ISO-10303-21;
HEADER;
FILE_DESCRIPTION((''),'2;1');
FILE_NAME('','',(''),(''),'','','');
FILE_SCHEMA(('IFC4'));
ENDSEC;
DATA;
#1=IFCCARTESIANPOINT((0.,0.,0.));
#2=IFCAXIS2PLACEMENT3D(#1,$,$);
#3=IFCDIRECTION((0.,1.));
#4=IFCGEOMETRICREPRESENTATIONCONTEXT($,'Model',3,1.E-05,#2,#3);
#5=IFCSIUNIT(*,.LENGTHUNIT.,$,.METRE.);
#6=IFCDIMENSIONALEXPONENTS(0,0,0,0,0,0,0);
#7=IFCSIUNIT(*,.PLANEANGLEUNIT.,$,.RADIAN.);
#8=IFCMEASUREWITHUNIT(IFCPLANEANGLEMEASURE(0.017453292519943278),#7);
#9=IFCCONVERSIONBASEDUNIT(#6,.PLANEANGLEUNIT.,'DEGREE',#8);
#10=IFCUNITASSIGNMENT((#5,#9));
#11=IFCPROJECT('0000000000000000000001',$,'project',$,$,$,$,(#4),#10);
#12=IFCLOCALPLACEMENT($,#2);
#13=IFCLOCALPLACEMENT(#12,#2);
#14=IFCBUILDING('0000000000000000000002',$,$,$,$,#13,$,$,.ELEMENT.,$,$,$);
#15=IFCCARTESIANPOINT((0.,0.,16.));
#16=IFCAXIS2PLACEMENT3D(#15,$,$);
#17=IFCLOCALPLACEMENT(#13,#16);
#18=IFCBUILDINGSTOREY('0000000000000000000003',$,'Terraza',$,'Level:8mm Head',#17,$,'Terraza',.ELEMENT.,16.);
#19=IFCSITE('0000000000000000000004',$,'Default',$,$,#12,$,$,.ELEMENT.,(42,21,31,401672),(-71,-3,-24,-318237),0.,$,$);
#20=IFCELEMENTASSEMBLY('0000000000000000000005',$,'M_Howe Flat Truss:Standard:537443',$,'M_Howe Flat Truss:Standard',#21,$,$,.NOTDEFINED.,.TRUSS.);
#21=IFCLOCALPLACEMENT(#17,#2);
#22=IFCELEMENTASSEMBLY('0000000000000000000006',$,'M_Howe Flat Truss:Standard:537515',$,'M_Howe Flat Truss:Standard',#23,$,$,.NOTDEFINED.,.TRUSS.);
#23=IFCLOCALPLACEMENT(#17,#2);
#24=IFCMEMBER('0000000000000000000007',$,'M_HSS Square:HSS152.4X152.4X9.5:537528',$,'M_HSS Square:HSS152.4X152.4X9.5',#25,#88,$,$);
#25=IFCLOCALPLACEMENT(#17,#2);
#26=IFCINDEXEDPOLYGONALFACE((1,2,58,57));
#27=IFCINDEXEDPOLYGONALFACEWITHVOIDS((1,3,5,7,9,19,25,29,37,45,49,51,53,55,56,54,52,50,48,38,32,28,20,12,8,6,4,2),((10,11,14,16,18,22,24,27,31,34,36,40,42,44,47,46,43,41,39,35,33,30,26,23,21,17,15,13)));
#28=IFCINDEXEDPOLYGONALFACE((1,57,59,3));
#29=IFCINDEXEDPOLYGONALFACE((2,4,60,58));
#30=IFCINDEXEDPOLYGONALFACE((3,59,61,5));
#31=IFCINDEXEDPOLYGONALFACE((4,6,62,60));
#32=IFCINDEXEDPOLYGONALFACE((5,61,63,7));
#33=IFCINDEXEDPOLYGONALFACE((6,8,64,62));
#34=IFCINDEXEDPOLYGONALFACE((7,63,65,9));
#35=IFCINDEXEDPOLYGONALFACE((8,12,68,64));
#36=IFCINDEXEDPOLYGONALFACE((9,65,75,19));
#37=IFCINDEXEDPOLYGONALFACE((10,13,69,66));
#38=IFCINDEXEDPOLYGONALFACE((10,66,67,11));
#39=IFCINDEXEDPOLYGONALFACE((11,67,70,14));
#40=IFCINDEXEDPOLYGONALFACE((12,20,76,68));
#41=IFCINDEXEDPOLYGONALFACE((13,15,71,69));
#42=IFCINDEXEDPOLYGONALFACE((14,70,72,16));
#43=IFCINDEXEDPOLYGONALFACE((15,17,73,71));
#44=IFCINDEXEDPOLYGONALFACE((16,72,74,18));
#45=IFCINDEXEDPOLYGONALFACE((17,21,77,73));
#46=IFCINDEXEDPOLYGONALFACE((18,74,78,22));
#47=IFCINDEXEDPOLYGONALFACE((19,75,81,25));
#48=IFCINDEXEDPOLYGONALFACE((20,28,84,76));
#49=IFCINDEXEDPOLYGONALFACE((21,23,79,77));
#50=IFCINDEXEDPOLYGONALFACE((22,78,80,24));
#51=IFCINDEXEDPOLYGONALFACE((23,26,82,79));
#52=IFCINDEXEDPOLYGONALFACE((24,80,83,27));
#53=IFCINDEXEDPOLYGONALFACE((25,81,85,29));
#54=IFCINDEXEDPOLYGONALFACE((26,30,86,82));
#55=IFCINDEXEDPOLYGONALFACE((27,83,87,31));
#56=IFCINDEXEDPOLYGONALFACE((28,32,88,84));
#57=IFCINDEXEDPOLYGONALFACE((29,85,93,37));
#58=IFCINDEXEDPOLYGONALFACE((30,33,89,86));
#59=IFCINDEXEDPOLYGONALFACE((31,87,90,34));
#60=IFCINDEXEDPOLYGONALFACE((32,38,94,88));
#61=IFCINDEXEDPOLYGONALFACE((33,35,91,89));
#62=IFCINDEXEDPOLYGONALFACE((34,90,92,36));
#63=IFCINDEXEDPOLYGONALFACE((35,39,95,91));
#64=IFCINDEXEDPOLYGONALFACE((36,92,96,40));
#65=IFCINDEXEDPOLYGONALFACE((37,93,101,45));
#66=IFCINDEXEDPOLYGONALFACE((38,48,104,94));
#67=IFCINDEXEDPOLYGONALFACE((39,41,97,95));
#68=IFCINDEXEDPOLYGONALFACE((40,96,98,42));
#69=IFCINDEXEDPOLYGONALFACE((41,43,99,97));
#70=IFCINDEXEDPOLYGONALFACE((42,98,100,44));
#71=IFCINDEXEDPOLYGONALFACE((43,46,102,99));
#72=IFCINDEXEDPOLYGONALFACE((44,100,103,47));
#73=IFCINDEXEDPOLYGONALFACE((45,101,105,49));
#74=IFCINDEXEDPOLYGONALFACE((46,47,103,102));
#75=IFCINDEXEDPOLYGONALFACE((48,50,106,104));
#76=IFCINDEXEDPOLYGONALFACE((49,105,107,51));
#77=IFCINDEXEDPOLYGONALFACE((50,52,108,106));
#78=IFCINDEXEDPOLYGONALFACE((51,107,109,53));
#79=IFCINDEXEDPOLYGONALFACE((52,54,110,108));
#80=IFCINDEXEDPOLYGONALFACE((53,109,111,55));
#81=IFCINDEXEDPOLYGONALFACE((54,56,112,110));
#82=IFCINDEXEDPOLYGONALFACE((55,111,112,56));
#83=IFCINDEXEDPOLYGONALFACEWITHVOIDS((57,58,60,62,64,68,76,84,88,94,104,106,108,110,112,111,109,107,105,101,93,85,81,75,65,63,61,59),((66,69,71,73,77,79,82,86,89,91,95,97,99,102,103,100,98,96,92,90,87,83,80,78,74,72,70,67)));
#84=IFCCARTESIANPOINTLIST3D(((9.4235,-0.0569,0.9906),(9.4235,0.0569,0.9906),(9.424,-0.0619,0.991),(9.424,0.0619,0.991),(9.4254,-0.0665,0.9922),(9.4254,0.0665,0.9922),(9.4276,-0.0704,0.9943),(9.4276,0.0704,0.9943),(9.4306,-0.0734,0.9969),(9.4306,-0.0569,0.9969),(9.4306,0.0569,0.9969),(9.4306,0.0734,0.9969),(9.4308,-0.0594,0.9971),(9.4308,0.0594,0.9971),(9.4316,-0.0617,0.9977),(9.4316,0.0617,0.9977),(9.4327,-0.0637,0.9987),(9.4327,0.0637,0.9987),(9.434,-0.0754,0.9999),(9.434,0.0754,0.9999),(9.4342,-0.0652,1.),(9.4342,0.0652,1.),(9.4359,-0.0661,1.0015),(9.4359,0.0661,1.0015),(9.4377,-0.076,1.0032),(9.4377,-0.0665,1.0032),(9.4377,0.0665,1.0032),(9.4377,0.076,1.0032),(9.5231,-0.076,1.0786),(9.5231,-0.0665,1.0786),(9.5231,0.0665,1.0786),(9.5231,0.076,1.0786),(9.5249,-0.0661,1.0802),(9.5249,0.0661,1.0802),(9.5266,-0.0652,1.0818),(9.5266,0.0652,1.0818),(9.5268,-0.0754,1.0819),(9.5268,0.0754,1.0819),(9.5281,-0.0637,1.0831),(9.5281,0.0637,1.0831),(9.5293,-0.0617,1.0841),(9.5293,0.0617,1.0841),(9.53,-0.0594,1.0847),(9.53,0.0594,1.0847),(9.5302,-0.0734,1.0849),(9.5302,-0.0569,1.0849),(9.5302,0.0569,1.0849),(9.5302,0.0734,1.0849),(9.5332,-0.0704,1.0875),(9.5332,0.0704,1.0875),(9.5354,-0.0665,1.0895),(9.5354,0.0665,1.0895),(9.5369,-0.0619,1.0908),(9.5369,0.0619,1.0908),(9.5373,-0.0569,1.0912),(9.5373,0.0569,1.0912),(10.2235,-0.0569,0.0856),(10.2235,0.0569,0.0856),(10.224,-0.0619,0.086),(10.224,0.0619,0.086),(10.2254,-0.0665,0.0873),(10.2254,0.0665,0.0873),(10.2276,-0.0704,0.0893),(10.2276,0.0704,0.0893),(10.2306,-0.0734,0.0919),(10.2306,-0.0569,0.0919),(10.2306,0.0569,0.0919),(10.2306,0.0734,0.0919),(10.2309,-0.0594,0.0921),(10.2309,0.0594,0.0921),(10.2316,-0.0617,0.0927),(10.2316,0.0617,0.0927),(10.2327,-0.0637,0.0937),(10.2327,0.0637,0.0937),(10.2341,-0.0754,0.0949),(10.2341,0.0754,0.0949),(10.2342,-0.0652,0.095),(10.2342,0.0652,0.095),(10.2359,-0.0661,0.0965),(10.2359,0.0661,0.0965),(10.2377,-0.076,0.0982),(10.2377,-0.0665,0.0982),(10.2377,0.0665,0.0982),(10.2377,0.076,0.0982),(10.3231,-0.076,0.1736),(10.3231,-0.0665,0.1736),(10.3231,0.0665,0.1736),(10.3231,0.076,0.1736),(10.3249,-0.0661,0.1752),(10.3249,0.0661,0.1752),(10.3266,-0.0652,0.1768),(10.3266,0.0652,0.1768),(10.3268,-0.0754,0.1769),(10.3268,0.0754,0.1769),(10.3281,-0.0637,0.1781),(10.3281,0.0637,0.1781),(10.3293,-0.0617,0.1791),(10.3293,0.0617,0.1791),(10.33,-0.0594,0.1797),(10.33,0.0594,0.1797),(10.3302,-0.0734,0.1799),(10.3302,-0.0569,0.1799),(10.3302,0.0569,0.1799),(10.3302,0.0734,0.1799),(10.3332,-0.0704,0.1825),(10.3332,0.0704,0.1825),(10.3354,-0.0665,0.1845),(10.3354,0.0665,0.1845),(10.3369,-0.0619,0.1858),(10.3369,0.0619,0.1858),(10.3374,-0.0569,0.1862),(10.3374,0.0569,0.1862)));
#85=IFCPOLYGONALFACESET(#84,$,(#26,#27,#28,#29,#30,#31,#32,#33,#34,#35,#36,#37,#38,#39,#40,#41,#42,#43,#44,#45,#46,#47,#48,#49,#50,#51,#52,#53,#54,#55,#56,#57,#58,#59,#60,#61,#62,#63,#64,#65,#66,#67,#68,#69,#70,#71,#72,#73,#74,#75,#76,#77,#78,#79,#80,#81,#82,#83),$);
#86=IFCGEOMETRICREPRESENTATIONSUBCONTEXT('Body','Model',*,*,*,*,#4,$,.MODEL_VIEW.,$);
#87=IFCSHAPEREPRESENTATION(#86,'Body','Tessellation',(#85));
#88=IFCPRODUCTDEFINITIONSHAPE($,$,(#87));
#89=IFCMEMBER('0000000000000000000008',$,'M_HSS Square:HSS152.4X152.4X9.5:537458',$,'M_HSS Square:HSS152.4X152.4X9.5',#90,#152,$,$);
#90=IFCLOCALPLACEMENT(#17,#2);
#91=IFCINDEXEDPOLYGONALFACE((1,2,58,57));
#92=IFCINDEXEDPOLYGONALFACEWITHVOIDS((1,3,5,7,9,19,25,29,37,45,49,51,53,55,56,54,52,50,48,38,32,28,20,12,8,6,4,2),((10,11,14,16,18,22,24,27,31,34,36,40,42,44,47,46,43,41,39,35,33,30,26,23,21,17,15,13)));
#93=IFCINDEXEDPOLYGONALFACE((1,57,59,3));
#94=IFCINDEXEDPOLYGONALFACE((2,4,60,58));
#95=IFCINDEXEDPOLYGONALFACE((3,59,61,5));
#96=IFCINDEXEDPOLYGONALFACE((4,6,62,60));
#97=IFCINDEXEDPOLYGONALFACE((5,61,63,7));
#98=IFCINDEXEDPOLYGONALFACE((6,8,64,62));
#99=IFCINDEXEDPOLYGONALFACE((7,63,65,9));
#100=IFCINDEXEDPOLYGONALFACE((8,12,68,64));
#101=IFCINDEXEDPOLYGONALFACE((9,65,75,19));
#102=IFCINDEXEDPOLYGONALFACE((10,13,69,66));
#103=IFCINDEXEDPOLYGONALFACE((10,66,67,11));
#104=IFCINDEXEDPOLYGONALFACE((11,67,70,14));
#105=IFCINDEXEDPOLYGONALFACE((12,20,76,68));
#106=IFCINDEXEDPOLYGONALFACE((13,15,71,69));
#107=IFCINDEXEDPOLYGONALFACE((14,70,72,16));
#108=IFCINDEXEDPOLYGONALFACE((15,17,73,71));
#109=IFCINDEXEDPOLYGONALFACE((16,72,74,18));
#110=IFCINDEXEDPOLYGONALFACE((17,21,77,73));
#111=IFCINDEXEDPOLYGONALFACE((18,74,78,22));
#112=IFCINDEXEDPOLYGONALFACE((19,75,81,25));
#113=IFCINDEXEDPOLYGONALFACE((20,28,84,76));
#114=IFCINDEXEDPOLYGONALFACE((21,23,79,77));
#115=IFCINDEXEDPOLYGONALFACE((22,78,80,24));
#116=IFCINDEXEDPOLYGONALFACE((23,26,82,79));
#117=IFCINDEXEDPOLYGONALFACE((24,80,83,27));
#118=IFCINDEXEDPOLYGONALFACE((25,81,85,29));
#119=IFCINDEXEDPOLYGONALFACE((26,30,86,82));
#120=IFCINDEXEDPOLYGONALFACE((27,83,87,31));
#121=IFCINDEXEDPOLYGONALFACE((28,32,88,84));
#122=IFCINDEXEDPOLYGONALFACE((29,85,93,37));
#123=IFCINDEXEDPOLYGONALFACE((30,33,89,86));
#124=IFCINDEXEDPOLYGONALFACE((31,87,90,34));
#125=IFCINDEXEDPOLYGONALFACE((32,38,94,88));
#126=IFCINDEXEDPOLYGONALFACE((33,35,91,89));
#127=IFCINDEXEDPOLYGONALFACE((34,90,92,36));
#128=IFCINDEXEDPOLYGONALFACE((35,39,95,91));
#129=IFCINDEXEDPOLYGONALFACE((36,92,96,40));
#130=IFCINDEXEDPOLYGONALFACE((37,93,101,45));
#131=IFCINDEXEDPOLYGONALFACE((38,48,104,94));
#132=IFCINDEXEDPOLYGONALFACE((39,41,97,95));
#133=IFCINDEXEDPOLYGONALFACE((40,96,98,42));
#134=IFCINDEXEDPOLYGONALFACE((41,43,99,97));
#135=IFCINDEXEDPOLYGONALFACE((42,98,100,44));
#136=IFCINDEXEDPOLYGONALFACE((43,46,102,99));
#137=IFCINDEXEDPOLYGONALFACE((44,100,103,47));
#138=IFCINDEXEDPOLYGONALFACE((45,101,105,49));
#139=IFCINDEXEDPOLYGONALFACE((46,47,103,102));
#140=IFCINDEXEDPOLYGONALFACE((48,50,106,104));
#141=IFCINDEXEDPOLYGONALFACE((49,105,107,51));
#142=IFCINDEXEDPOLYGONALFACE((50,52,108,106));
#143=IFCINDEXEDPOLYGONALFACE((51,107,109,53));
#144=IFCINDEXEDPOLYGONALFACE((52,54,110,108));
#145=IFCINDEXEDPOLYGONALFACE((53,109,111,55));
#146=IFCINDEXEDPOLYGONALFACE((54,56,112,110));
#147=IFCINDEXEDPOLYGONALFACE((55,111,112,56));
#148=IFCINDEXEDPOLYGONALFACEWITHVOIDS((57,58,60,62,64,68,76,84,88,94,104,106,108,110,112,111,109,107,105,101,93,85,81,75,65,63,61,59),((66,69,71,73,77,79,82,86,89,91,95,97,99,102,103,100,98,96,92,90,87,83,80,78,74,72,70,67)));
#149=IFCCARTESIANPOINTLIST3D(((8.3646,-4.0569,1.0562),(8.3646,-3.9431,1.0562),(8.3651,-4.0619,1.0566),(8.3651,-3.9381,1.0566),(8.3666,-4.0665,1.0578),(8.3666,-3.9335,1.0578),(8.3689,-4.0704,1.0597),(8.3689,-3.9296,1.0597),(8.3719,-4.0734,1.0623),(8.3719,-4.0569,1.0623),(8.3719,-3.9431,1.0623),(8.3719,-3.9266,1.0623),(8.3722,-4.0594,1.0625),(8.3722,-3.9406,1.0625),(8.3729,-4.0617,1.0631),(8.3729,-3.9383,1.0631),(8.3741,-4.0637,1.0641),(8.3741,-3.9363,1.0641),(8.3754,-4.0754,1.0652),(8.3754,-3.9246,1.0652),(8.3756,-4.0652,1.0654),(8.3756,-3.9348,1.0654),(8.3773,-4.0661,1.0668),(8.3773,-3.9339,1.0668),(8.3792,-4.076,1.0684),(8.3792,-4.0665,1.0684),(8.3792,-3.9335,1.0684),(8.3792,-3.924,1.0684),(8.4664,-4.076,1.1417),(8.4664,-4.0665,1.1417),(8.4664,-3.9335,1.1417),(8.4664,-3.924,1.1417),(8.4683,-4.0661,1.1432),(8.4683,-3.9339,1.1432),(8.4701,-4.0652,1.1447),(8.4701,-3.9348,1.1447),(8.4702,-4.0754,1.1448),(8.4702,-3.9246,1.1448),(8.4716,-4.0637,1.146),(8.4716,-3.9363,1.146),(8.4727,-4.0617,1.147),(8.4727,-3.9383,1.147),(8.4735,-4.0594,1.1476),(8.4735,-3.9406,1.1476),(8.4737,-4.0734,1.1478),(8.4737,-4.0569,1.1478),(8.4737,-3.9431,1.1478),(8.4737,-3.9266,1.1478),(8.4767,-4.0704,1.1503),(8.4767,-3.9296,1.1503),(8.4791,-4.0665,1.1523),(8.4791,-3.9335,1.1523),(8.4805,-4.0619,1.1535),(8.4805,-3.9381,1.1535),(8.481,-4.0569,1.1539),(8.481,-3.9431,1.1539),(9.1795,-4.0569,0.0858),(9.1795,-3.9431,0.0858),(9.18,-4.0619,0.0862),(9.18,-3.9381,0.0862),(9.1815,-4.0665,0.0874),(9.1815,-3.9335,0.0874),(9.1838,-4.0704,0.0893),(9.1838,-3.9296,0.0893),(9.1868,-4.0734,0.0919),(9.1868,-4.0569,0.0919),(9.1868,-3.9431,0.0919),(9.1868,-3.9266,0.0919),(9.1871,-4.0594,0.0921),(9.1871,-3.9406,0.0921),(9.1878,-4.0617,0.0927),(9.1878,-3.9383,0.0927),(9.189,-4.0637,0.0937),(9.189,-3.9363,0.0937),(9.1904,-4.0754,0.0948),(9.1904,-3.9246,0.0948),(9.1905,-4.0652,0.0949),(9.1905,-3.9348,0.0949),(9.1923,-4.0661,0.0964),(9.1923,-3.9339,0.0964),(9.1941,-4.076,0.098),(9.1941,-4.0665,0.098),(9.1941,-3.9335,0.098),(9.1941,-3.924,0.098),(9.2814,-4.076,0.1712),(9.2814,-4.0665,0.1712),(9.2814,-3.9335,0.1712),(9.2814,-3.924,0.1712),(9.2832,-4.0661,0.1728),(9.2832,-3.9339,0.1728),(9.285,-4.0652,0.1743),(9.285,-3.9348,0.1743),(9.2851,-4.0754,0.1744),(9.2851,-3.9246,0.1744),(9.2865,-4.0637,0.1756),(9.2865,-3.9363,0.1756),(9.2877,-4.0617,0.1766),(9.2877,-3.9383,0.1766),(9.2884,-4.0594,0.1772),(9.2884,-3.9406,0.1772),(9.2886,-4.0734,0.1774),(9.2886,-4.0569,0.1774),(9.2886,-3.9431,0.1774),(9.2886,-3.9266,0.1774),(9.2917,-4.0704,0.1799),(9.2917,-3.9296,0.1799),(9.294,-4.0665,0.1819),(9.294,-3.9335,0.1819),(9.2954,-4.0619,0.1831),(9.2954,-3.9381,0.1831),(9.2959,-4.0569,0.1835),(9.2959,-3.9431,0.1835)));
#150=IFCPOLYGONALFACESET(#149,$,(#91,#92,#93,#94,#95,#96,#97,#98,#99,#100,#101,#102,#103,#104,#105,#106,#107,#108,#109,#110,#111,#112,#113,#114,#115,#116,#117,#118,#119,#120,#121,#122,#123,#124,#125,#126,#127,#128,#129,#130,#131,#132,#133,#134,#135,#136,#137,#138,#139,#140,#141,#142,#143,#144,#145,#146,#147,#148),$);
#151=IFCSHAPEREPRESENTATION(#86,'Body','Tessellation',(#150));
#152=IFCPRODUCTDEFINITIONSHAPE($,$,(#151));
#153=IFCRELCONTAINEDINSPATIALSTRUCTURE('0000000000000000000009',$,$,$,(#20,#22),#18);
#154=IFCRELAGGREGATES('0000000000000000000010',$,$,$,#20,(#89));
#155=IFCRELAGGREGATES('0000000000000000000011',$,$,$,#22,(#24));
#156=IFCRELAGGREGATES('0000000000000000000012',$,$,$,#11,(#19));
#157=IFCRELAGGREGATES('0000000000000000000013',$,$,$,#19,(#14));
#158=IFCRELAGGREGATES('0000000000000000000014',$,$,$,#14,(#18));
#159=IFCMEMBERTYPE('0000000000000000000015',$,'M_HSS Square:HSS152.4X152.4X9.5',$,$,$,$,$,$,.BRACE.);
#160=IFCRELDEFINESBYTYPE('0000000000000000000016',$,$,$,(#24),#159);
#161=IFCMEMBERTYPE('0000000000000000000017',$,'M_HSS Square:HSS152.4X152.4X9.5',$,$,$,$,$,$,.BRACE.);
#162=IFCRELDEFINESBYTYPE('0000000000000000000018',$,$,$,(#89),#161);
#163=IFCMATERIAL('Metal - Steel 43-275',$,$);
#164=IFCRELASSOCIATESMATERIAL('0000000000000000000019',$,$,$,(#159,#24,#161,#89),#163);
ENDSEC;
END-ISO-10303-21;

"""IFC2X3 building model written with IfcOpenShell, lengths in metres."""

from ifc_helpers import new_model, entity, si_unit, converted_unit, direction, frame, frame_2d, origin, place, context, subcontext, project, spatial, polyline, circle_curve, parameter, trimmed, segment, composite_curve, outline, extrude, source, transform, mapped, material, type_object, type_shapes, element, aggregate, save


model = new_model("IFC2X3")

# Units and contexts
model_context = context("Model", 3, precision=1e-05, world=origin(), true_north=direction((0.0, 1.0)))
body_context = subcontext(model_context, "Body", "Model", "MODEL_VIEW")
ifc_project = project(units=[si_unit("LENGTHUNIT", "METRE"), converted_unit("PLANEANGLEUNIT", "DEGREE", entity("IfcPlaneAngleMeasure", 0.017453292519943278), si_unit("PLANEANGLEUNIT", "RADIAN"), dimensions=[0, 0, 0, 0, 0, 0, 0])], contexts=[model_context])

# Site, building, storey
site_placement = place(None, origin())
site = spatial("IfcSite", under=ifc_project, at=site_placement, Name="Default", CompositionType="ELEMENT", RefLatitude=(42, 21, 31, 401672), RefLongitude=(-71, -3, -24, -318237), RefElevation=0.0)
building_placement = place(site_placement, origin())
building = spatial("IfcBuilding", under=site, at=building_placement, CompositionType="ELEMENT")
storey_placement = place(building_placement, frame((0.0, 0.0, 16.0)))
storey = spatial("IfcBuildingStorey", under=building, at=storey_placement, Name="Terraza", ObjectType="Level:8mm Head", LongName="Terraza", CompositionType="ELEMENT", Elevation=16.0)

# Element assemblies
ifc_material_1 = material(Name="Metal - Steel 43-275")
assembly_1_placement = place(storey_placement, origin())
assembly_1 = element("IfcElementAssembly", 1, at=assembly_1_placement, inside=storey, Name="M_Howe Flat Truss:Standard:537443", ObjectType="M_Howe Flat Truss:Standard", AssemblyPlace="NOTDEFINED", PredefinedType="TRUSS")
assembly_2_placement = place(storey_placement, origin())
assembly_2 = element("IfcElementAssembly", 2, at=assembly_2_placement, inside=storey, Name="M_Howe Flat Truss:Standard:537515", ObjectType="M_Howe Flat Truss:Standard", AssemblyPlace="NOTDEFINED", PredefinedType="TRUSS")

# Members
member_type_1 = type_object("IfcMemberType", Name="M_HSS Square:HSS152.4X152.4X9.5", PredefinedType="BRACE", material=ifc_material_1)
shared_shape_1 = source(origin(), body_context, "Body", "SweptSolid", [
    extrude(outline(composite_curve([segment(polyline([(-0.0569, -0.076), (0.0569, -0.076)]), True, "CONTINUOUS"), segment(trimmed(circle_curve(frame_2d((0.0569, -0.0569), x_axis=(0.0, 1.0)), 0.0191), [parameter(180.0)], [parameter(270.0)], True, "PARAMETER"), True, "CONTINUOUS"), segment(polyline([(0.076, -0.0569), (0.076, 0.0569)]), True, "CONTINUOUS"), segment(trimmed(circle_curve(frame_2d((0.0569, 0.0569), x_axis=(0.0, 1.0)), 0.0191), [parameter(270.0)], [parameter(0.0)], True, "PARAMETER"), True, "CONTINUOUS"), segment(polyline([(0.0569, 0.076), (-0.0569, 0.076)]), True, "CONTINUOUS"), segment(trimmed(circle_curve(frame_2d((-0.0569, 0.0569), x_axis=(0.0, 1.0)), 0.0191), [parameter(0.0)], [parameter(90.0)], True, "PARAMETER"), True, "CONTINUOUS"), segment(polyline([(-0.076, 0.0569), (-0.076, -0.0569)]), True, "CONTINUOUS"), segment(trimmed(circle_curve(frame_2d((-0.0569, -0.0569), x_axis=(0.0, 1.0)), 0.0191), [parameter(90.0)], [parameter(180.0)], True, "PARAMETER"), True, "CONTINUOUS")], self_intersect=False), holes=[composite_curve([segment(trimmed(circle_curve(frame_2d((-0.0569, 0.0569), x_axis=(0.0, 1.0)), 0.0095), [parameter(360.0)], [parameter(90.0)], True, "PARAMETER"), False, "CONTINUOUS"), segment(polyline([(-0.0569, 0.0665), (0.0569, 0.0665)]), True, "CONTINUOUS"), segment(trimmed(circle_curve(frame_2d((0.0569, 0.0569), x_axis=(0.0, 1.0)), 0.0095), [parameter(270.0)], [parameter(360.0)], True, "PARAMETER"), False, "CONTINUOUS"), segment(polyline([(0.0665, 0.0569), (0.0665, -0.0569)]), True, "CONTINUOUS"), segment(trimmed(circle_curve(frame_2d((0.0569, -0.0569), x_axis=(0.0, 1.0)), 0.0095), [parameter(180.0)], [parameter(270.0)], True, "PARAMETER"), False, "CONTINUOUS"), segment(polyline([(0.0569, -0.0665), (-0.0569, -0.0665)]), True, "CONTINUOUS"), segment(trimmed(circle_curve(frame_2d((-0.0569, -0.0569), x_axis=(0.0, 1.0)), 0.0095), [parameter(90.0)], [parameter(180.0)], True, "PARAMETER"), False, "CONTINUOUS"), segment(polyline([(-0.0665, -0.0569), (-0.0665, 0.0569)]), True, "CONTINUOUS")], self_intersect=False)]), frame((-0.5968, 0.0, 0.0), z_axis=(1.0, 0.0, 0.0), x_axis=(0.0, 0.0, -1.0)), (0.0, 0.0, 1.0), 1.2079),
])
type_shapes(member_type_1, [shared_shape_1])
member_1_placement = place(assembly_2_placement, frame((9.8757, 0.0, 0.5937), z_axis=(-0.749231, 0.0, -0.662309), x_axis=(0.662309, 0.0, -0.749231)))
member_1 = element("IfcMember", 3, at=member_1_placement, type_object=member_type_1, material=ifc_material_1, Name="M_HSS Square:HSS152.4X152.4X9.5:537528", ObjectType="M_HSS Square:HSS152.4X152.4X9.5", context=body_context, shape_type="MappedRepresentation", body=[
    mapped(shared_shape_1, transform((0.0, 0.0, 0.0), scale=1.0)),
])
member_type_2 = type_object("IfcMemberType", Name="M_HSS Square:HSS152.4X152.4X9.5", PredefinedType="BRACE", material=ifc_material_1)
shared_shape_2 = source(origin(), body_context, "Body", "SweptSolid", [
    extrude(outline(composite_curve([segment(polyline([(-0.0569, -0.076), (0.0569, -0.076)]), True, "CONTINUOUS"), segment(trimmed(circle_curve(frame_2d((0.0569, -0.0569), x_axis=(0.0, 1.0)), 0.0191), [parameter(180.0)], [parameter(270.0)], True, "PARAMETER"), True, "CONTINUOUS"), segment(polyline([(0.076, -0.0569), (0.076, 0.0569)]), True, "CONTINUOUS"), segment(trimmed(circle_curve(frame_2d((0.0569, 0.0569), x_axis=(0.0, 1.0)), 0.0191), [parameter(270.0)], [parameter(0.0)], True, "PARAMETER"), True, "CONTINUOUS"), segment(polyline([(0.0569, 0.076), (-0.0569, 0.076)]), True, "CONTINUOUS"), segment(trimmed(circle_curve(frame_2d((-0.0569, 0.0569), x_axis=(0.0, 1.0)), 0.0191), [parameter(0.0)], [parameter(90.0)], True, "PARAMETER"), True, "CONTINUOUS"), segment(polyline([(-0.076, 0.0569), (-0.076, -0.0569)]), True, "CONTINUOUS"), segment(trimmed(circle_curve(frame_2d((-0.0569, -0.0569), x_axis=(0.0, 1.0)), 0.0191), [parameter(90.0)], [parameter(180.0)], True, "PARAMETER"), True, "CONTINUOUS")], self_intersect=False), holes=[composite_curve([segment(trimmed(circle_curve(frame_2d((-0.0569, 0.0569), x_axis=(0.0, 1.0)), 0.0095), [parameter(360.0)], [parameter(90.0)], True, "PARAMETER"), False, "CONTINUOUS"), segment(polyline([(-0.0569, 0.0665), (0.0569, 0.0665)]), True, "CONTINUOUS"), segment(trimmed(circle_curve(frame_2d((0.0569, 0.0569), x_axis=(0.0, 1.0)), 0.0095), [parameter(270.0)], [parameter(360.0)], True, "PARAMETER"), False, "CONTINUOUS"), segment(polyline([(0.0665, 0.0569), (0.0665, -0.0569)]), True, "CONTINUOUS"), segment(trimmed(circle_curve(frame_2d((0.0569, -0.0569), x_axis=(0.0, 1.0)), 0.0095), [parameter(180.0)], [parameter(270.0)], True, "PARAMETER"), False, "CONTINUOUS"), segment(polyline([(0.0569, -0.0665), (-0.0569, -0.0665)]), True, "CONTINUOUS"), segment(trimmed(circle_curve(frame_2d((-0.0569, -0.0569), x_axis=(0.0, 1.0)), 0.0095), [parameter(90.0)], [parameter(180.0)], True, "PARAMETER"), False, "CONTINUOUS"), segment(polyline([(-0.0665, -0.0569), (-0.0665, 0.0569)]), True, "CONTINUOUS")], self_intersect=False)]), frame((-0.6269, 0.0, 0.0), z_axis=(1.0, 0.0, 0.0), x_axis=(0.0, 0.0, -1.0)), (0.0, 0.0, 1.0), 1.2672),
])
type_shapes(member_type_2, [shared_shape_2])
member_2_placement = place(assembly_1_placement, frame((8.8259, -4.0, 0.625), z_axis=(-0.765786, 0.0, -0.643096), x_axis=(0.643096, 0.0, -0.765786)))
member_2 = element("IfcMember", 4, at=member_2_placement, type_object=member_type_2, material=ifc_material_1, Name="M_HSS Square:HSS152.4X152.4X9.5:537458", ObjectType="M_HSS Square:HSS152.4X152.4X9.5", context=body_context, shape_type="MappedRepresentation", body=[
    mapped(shared_shape_2, transform((0.0, 0.0, 0.0), scale=1.0)),
])
aggregate(assembly_1, [member_2])
aggregate(assembly_2, [member_1])

save(model, "model.ifc")
